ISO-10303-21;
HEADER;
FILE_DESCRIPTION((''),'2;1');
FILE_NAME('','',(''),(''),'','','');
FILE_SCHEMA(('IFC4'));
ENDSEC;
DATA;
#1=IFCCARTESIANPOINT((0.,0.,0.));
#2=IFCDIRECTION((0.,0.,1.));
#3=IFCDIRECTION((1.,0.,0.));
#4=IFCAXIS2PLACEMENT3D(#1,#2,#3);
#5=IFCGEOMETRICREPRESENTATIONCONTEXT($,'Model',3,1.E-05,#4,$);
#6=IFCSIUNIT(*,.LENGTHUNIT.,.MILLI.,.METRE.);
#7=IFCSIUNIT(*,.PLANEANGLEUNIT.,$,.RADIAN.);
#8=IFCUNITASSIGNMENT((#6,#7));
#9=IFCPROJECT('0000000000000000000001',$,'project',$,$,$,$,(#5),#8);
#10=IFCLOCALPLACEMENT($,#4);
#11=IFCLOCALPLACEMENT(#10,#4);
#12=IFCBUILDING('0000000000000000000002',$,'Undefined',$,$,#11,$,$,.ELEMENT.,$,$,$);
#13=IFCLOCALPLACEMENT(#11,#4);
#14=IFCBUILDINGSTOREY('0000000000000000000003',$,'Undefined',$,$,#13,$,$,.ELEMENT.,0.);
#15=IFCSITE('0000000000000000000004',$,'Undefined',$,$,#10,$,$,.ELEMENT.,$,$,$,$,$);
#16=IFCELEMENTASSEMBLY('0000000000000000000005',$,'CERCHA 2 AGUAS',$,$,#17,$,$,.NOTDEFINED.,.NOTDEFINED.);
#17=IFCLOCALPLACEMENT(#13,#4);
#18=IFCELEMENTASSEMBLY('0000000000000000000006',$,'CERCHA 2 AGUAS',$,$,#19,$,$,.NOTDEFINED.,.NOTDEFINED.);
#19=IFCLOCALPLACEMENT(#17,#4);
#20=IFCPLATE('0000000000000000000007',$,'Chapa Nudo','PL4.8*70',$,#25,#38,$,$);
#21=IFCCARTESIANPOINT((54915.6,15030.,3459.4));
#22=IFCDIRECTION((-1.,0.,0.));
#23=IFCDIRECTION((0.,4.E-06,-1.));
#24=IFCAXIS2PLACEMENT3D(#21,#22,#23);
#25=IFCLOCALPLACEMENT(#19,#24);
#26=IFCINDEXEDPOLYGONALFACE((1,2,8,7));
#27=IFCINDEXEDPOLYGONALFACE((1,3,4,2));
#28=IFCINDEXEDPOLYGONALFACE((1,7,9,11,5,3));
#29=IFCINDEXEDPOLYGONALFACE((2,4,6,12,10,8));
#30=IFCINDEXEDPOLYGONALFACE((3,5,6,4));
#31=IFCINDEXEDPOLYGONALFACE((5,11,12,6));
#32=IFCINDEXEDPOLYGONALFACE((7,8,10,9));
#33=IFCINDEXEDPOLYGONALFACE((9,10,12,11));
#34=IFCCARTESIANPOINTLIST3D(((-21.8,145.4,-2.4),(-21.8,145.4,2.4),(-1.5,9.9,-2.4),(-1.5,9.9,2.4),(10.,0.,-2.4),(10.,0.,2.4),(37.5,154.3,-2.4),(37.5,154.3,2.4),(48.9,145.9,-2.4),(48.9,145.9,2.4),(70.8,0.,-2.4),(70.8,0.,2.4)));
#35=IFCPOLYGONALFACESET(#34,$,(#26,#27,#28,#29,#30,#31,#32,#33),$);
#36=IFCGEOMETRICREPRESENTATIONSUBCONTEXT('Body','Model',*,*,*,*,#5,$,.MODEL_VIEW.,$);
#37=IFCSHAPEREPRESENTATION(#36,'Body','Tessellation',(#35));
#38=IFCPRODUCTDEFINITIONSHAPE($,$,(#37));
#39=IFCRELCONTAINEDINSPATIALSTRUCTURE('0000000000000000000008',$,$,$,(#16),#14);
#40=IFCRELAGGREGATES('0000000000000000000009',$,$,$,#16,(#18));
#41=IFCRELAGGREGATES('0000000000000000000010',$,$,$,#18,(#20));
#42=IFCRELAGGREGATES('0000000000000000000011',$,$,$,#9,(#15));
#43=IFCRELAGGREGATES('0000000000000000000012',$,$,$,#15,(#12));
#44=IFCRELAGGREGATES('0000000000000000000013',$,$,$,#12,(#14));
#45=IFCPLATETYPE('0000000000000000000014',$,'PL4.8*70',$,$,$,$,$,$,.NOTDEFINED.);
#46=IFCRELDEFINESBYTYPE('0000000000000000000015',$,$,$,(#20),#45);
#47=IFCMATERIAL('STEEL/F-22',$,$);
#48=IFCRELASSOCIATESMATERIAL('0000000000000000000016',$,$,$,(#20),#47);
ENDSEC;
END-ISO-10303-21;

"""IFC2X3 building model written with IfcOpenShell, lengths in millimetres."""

from ifc_helpers import new_model, si_unit, frame, origin_with_axes, place, context, subcontext, project, spatial, polyline, outline, extrude, material, type_object, element, aggregate, save


model = new_model("IFC2X3")

# Units and contexts
model_context = context("Model", 3, precision=1e-05, world=origin_with_axes())
body_context = subcontext(model_context, "Body", "Model", "MODEL_VIEW")
ifc_project = project(units=[si_unit("LENGTHUNIT", "METRE", prefix="MILLI"), si_unit("PLANEANGLEUNIT", "RADIAN")], contexts=[model_context])

# Site, building, storey
site_placement = place(None, origin_with_axes())
site = spatial("IfcSite", under=ifc_project, at=site_placement, Name="Undefined", CompositionType="ELEMENT")
building_placement = place(site_placement, origin_with_axes())
building = spatial("IfcBuilding", under=site, at=building_placement, Name="Undefined", CompositionType="ELEMENT")
storey_placement = place(building_placement, origin_with_axes())
storey = spatial("IfcBuildingStorey", under=building, at=storey_placement, Name="Undefined", CompositionType="ELEMENT", Elevation=0.0)

# Element assemblies
assembly_1_placement = place(storey_placement, origin_with_axes())
assembly_1 = element("IfcElementAssembly", 1, at=assembly_1_placement, inside=storey, Name="CERCHA 2 AGUAS", AssemblyPlace="NOTDEFINED", PredefinedType="NOTDEFINED")
assembly_2_placement = place(assembly_1_placement, origin_with_axes())
assembly_2 = element("IfcElementAssembly", 2, at=assembly_2_placement, Name="CERCHA 2 AGUAS", AssemblyPlace="NOTDEFINED", PredefinedType="NOTDEFINED")
ifc_material_1 = material(Name="STEEL/F-22")

aggregate(assembly_1, [assembly_2])

# Plate
plate_type_1 = type_object("IfcPlateType", Name="PL4.8*70", PredefinedType="NOTDEFINED")
plate_1_placement = place(assembly_2_placement, frame((54915.6, 15030.0, 3459.4), z_axis=(-1.0, 0.0, 0.0), x_axis=(0.0, 0.000004, -1.0)))
plate_1 = element("IfcPlate", 3, at=plate_1_placement, type_object=plate_type_1, material=ifc_material_1, Name="Chapa Nudo", Description="PL4.8*70", context=body_context, shape_type="SweptSolid", body=[
    extrude(outline(polyline([(-1.5, 9.9), (10.0, 0.0), (70.8, 0.0), (70.8, 0.0), (48.9, 145.9), (37.5, 154.3), (-21.8, 145.4), (-1.5, 9.9)])), frame((0.0, 0.0, -2.4), z_axis=(0.0, 0.0, 1.0), x_axis=(1.0, 0.0, 0.0)), (0.0, 0.0, 1.0), 4.8),
])

aggregate(assembly_2, [plate_1])

save(model, "model.ifc")
